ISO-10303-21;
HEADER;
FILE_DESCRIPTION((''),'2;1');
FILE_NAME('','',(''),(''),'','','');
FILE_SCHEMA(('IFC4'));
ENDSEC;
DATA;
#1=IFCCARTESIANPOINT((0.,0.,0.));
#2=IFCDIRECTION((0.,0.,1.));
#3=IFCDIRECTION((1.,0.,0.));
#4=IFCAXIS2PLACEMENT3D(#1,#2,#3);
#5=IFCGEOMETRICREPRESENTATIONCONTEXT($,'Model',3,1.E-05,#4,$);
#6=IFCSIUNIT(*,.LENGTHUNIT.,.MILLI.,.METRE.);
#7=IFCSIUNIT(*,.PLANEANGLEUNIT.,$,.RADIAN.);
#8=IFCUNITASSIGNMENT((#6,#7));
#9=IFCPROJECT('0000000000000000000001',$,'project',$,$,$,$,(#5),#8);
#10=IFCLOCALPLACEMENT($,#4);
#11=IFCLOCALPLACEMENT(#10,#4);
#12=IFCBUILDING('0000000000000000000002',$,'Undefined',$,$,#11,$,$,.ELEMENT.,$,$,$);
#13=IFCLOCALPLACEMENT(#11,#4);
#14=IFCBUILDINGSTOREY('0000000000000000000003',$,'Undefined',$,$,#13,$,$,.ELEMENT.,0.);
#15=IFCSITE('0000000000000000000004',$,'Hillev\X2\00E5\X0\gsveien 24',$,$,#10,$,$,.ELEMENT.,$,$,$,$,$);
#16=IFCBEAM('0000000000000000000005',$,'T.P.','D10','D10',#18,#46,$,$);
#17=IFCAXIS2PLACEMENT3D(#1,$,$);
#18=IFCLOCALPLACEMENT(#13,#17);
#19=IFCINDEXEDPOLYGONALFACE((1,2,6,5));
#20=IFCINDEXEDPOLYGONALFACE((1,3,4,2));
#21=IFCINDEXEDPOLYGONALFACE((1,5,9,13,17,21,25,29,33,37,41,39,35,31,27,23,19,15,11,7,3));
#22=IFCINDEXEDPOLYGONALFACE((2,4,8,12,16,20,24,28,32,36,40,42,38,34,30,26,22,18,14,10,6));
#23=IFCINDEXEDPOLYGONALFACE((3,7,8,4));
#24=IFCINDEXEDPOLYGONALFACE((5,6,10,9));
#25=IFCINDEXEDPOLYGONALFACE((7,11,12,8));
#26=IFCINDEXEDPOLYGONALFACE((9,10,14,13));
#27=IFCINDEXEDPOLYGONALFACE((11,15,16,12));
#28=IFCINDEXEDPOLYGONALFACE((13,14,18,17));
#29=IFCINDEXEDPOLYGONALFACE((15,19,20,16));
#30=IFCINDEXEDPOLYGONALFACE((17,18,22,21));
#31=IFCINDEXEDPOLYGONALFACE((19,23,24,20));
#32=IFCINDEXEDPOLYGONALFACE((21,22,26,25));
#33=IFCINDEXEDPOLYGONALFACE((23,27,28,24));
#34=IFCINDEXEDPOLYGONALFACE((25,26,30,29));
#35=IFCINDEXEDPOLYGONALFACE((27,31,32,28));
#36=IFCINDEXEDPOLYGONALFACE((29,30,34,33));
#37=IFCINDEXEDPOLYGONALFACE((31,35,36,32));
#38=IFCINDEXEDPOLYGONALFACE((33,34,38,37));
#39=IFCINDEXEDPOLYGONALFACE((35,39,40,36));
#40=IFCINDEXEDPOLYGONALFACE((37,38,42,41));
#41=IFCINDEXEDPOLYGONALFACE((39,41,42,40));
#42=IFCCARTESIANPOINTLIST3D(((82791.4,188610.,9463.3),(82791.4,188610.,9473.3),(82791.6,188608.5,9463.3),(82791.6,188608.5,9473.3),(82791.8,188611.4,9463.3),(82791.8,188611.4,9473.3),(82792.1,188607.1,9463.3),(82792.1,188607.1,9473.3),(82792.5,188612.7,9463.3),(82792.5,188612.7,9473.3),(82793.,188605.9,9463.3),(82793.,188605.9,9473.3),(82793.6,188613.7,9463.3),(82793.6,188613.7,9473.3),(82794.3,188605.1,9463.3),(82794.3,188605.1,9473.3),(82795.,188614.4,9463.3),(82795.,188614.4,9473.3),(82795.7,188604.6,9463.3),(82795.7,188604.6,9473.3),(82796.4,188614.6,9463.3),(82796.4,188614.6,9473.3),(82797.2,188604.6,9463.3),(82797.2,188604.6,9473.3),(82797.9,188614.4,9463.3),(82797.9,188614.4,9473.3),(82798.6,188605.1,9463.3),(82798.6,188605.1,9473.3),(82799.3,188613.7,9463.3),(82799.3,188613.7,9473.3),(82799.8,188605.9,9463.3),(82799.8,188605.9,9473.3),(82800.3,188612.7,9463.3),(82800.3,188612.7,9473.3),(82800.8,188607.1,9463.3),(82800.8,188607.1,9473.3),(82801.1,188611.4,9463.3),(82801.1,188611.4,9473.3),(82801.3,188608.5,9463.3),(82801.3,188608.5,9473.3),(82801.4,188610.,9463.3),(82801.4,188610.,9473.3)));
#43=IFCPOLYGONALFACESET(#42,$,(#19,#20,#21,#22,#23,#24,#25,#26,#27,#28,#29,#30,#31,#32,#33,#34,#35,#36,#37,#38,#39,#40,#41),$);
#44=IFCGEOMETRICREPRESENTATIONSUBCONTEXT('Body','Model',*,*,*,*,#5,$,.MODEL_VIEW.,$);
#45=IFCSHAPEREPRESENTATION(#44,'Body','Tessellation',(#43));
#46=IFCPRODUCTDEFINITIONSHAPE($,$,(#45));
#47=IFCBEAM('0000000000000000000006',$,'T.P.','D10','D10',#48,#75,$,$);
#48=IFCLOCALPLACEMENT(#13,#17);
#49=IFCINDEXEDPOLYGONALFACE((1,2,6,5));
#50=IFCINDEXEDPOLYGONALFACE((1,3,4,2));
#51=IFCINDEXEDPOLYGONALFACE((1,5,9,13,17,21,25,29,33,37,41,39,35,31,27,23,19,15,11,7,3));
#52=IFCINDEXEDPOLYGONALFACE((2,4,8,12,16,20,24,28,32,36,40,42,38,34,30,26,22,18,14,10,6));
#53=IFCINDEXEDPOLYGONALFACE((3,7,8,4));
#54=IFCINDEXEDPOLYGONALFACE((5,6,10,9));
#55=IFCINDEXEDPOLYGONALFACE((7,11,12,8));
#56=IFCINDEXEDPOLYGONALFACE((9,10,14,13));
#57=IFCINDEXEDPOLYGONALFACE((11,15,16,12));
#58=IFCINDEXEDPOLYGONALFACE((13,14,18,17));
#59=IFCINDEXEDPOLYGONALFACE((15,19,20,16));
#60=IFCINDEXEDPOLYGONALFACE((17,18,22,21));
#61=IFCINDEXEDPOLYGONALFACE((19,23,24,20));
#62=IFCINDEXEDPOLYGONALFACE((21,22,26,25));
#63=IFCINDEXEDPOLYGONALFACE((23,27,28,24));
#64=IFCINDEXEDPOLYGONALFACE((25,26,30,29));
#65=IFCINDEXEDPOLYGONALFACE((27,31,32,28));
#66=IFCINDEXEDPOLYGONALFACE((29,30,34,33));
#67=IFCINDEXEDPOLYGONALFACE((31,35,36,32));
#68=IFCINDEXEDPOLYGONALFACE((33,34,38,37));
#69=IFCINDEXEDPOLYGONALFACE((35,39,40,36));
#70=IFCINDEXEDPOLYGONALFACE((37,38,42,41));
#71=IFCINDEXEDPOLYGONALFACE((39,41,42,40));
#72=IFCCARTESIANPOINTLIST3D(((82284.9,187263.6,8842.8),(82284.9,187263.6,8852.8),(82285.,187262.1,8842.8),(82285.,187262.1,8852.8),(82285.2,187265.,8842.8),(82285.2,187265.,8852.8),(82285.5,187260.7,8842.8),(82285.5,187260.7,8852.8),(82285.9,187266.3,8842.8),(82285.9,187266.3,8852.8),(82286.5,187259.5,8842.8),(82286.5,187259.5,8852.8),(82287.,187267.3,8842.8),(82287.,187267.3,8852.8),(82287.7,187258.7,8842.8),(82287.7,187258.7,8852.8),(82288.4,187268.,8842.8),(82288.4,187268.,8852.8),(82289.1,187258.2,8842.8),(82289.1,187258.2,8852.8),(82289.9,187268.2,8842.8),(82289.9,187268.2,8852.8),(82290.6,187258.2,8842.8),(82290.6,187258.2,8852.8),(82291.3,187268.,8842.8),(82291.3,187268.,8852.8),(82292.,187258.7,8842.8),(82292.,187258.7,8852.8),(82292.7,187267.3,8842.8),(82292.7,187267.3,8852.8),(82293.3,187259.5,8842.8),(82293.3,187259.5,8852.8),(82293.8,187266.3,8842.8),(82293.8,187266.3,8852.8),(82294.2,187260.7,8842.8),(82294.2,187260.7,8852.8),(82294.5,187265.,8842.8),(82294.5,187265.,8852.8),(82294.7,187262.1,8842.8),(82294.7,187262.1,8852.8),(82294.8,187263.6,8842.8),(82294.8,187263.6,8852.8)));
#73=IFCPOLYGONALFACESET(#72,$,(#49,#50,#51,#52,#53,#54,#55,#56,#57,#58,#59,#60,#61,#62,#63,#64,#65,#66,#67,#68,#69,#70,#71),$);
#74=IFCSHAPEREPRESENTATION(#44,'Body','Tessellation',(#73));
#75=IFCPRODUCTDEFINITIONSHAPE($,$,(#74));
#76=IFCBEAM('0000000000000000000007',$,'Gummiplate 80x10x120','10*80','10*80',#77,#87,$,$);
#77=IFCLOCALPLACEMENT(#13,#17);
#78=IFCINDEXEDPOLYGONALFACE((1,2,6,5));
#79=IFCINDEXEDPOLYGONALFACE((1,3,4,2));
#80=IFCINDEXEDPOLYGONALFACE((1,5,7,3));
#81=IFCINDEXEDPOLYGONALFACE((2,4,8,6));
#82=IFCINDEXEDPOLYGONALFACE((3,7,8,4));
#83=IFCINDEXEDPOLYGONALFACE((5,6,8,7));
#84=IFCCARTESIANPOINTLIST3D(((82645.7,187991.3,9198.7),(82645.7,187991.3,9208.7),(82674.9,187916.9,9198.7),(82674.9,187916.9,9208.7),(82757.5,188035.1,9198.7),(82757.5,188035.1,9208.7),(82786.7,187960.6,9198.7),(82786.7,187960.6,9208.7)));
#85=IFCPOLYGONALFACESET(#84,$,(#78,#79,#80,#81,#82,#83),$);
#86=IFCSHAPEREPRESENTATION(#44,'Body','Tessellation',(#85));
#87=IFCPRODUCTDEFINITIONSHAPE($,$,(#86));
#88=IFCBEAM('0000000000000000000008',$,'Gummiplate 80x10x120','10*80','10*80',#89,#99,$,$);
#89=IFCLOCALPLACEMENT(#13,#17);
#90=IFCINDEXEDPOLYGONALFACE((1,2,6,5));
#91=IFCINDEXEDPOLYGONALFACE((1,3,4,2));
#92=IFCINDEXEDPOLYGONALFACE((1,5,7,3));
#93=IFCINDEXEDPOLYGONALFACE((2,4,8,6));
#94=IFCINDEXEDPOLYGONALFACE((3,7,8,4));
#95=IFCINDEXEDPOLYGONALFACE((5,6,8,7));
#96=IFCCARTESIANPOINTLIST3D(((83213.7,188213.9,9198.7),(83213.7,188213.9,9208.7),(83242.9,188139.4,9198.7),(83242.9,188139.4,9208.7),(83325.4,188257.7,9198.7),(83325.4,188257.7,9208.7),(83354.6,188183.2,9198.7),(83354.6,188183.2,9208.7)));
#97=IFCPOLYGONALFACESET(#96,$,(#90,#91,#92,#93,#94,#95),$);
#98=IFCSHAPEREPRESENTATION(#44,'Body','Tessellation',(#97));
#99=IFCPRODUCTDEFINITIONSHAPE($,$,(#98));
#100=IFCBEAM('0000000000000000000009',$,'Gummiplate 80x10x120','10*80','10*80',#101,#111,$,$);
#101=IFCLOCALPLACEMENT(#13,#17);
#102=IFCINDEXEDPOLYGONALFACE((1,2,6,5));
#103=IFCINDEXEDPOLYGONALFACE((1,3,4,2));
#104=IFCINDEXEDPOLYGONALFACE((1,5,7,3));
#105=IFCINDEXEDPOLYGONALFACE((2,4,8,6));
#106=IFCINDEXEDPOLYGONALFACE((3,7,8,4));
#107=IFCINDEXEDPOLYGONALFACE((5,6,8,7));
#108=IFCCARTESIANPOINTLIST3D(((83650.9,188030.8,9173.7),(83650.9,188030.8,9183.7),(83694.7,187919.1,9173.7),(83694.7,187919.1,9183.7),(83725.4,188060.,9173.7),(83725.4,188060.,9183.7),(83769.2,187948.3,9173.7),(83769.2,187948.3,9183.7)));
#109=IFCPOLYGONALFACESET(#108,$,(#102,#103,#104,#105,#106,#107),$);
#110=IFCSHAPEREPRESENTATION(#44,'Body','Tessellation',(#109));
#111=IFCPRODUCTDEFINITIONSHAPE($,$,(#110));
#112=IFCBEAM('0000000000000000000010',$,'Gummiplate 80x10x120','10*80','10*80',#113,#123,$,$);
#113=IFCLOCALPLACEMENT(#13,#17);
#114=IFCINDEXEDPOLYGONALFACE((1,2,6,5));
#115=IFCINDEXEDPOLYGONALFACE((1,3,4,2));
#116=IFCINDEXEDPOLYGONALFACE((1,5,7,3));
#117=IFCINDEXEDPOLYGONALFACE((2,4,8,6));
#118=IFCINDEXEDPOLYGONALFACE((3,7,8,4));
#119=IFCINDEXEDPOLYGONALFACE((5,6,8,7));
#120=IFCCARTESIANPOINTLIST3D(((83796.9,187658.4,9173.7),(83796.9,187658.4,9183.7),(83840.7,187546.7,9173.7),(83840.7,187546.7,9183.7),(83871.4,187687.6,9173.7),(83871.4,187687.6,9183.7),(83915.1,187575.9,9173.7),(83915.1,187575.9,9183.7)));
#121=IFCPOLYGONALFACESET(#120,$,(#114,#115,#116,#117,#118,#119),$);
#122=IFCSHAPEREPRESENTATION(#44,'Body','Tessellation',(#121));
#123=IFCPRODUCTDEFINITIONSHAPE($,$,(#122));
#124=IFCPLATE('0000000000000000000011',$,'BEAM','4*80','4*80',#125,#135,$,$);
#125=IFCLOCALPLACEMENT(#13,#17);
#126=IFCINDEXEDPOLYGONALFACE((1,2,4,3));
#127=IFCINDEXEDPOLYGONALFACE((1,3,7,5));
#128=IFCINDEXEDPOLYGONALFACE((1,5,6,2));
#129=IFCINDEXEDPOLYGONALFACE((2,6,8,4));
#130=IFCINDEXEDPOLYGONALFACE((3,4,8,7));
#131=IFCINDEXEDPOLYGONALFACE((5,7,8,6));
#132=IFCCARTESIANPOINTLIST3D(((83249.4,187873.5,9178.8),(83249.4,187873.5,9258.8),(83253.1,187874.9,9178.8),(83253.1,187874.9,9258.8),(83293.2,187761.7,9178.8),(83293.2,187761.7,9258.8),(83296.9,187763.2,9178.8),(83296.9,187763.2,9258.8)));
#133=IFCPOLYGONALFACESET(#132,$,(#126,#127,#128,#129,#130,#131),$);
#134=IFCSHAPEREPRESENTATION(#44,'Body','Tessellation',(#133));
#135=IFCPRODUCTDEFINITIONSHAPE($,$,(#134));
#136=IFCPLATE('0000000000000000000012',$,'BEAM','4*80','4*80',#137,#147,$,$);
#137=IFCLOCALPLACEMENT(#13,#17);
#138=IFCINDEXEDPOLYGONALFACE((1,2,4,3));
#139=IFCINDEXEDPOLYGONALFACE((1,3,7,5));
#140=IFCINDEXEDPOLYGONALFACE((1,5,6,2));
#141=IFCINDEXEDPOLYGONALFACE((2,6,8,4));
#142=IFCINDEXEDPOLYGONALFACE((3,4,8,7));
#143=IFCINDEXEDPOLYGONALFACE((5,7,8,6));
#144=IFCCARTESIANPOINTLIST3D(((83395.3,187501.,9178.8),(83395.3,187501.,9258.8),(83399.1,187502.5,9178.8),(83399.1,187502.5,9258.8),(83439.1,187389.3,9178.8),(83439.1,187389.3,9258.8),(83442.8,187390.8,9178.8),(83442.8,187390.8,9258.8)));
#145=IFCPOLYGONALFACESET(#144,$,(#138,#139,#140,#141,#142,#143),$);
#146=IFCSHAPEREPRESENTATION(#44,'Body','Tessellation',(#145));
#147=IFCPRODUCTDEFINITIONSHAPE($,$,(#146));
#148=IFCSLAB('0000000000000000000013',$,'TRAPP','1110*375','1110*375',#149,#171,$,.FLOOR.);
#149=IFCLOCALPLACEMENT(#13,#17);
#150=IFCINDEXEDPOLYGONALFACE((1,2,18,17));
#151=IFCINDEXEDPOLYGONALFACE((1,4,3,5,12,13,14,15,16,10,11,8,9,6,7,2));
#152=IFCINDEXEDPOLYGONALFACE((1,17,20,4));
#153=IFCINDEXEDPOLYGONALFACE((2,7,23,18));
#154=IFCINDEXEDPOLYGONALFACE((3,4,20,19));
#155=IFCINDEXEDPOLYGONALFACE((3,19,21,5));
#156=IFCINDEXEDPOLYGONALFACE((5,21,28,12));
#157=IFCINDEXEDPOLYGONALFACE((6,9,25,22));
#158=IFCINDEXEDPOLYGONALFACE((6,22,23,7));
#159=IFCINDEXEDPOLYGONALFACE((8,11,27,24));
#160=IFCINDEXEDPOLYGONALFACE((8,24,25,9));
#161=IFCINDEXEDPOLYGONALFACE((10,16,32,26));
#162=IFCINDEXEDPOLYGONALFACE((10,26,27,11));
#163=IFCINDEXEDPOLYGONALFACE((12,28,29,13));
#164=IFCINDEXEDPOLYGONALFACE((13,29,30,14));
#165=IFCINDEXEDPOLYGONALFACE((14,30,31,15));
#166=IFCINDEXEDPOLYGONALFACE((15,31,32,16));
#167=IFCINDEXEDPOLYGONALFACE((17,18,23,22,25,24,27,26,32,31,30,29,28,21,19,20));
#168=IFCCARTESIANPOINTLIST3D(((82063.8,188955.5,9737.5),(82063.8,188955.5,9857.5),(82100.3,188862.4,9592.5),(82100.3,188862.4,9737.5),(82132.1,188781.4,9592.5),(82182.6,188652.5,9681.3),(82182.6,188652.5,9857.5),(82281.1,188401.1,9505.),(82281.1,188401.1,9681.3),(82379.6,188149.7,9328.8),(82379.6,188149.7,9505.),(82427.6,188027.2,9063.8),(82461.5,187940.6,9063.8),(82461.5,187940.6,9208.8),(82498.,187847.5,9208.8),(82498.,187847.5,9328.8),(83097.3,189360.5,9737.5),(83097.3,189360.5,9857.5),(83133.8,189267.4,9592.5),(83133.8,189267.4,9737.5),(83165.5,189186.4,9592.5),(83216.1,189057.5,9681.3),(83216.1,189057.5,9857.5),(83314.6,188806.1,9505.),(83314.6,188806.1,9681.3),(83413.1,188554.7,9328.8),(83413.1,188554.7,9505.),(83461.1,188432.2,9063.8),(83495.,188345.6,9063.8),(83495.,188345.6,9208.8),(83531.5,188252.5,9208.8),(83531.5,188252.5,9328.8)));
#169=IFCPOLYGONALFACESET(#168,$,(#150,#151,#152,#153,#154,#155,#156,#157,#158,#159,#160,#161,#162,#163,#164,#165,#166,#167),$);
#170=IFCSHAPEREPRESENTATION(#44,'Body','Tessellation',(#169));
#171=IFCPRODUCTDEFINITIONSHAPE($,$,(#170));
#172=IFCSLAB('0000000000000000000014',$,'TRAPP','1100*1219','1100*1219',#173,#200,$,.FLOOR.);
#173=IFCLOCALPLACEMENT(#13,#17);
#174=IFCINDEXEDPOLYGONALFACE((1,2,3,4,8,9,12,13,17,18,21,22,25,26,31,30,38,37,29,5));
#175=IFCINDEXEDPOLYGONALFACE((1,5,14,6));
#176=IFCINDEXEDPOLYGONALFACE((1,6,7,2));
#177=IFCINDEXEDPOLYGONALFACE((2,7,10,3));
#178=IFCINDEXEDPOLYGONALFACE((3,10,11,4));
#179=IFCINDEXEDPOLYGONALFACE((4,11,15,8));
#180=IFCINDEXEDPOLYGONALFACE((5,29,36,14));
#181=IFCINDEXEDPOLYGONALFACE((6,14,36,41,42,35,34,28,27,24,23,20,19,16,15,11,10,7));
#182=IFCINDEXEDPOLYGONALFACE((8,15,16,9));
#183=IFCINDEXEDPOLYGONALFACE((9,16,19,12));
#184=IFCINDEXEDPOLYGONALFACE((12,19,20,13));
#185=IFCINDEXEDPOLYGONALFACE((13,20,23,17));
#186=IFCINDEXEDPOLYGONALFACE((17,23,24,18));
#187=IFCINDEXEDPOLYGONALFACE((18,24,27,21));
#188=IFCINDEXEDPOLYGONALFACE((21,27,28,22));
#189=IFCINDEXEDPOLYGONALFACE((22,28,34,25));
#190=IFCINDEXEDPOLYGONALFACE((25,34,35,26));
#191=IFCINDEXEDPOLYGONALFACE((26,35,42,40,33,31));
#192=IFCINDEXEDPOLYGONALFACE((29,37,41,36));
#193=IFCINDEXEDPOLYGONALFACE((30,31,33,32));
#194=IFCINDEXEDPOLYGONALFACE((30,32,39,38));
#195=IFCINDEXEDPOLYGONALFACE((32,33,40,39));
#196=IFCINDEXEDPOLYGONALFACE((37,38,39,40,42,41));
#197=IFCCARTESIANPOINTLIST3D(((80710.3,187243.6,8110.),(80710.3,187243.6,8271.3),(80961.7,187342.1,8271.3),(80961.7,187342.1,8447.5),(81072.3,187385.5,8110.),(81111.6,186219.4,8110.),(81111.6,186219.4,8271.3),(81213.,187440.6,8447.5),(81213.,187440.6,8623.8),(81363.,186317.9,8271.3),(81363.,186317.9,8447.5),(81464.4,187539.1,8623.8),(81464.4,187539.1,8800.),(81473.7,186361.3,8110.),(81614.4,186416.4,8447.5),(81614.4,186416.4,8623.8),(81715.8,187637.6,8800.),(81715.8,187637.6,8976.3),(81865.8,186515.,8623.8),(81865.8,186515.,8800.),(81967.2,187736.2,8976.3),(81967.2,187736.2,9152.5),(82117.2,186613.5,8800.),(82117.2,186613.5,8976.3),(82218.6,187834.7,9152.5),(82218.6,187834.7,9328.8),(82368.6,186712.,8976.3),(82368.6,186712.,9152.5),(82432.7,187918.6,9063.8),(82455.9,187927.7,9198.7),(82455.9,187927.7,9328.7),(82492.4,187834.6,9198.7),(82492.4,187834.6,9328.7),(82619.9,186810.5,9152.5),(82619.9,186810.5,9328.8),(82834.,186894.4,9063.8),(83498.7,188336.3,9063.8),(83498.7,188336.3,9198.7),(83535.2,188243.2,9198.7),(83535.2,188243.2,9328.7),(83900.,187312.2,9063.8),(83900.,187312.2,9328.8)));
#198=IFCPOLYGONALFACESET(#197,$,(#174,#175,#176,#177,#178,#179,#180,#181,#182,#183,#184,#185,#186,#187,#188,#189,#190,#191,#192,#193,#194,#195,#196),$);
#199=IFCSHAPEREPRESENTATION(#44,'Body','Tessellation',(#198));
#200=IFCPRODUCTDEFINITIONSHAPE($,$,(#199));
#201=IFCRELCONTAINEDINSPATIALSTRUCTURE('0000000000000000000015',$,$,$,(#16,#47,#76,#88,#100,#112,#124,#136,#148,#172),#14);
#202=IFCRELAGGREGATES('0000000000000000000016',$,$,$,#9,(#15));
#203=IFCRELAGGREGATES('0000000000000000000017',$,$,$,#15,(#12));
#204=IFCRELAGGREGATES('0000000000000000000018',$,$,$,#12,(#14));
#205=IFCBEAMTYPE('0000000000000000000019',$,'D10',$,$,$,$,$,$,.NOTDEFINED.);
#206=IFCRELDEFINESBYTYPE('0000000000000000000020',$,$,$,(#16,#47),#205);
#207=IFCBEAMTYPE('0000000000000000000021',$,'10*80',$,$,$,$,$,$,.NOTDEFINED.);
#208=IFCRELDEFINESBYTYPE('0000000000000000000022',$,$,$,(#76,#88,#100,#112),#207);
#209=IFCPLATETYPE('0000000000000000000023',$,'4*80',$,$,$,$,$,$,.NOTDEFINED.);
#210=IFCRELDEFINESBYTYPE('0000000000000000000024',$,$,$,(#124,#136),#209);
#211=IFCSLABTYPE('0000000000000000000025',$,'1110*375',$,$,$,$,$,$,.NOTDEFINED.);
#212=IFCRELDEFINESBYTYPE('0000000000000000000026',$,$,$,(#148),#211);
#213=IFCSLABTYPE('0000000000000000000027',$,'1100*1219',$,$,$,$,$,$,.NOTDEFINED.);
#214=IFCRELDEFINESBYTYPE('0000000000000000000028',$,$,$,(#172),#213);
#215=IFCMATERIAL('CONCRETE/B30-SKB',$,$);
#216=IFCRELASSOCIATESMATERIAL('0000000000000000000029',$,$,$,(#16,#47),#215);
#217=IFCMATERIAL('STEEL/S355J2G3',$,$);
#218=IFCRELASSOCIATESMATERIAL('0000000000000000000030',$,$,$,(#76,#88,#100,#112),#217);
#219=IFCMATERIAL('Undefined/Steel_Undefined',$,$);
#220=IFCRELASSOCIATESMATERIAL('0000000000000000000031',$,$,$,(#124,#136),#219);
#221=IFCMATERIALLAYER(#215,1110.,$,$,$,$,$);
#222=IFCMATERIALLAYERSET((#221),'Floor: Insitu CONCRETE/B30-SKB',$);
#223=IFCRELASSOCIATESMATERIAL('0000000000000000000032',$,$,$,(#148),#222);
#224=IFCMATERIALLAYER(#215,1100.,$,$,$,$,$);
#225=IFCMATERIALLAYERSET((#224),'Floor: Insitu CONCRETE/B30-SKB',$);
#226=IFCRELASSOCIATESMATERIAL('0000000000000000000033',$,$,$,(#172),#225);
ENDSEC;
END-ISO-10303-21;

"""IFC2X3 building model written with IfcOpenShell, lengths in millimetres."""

from ifc_helpers import new_model, si_unit, frame, frame_2d, origin_with_axes, place, context, subcontext, project, spatial, polyline, rectangle, circle, outline, extrude, boolean, material, layer, layer_set, layer_usage, type_object, element, save


model = new_model("IFC2X3")

# Units and contexts
model_context = context("Model", 3, precision=1e-05, world=origin_with_axes())
body_context = subcontext(model_context, "Body", "Model", "MODEL_VIEW")
ifc_project = project(units=[si_unit("LENGTHUNIT", "METRE", prefix="MILLI"), si_unit("PLANEANGLEUNIT", "RADIAN")], contexts=[model_context])

# Site, building, storey
site_placement = place(None, origin_with_axes())
site = spatial("IfcSite", under=ifc_project, at=site_placement, Name="Hillevågsveien 24", CompositionType="ELEMENT")
building_placement = place(site_placement, origin_with_axes())
building = spatial("IfcBuilding", under=site, at=building_placement, Name="Undefined", CompositionType="ELEMENT")
storey_placement = place(building_placement, origin_with_axes())
storey = spatial("IfcBuildingStorey", under=building, at=storey_placement, Name="Undefined", CompositionType="ELEMENT", Elevation=0.0)

# Beams
ifc_material_1 = material(Name="Undefined/Steel_Undefined")
ifc_material_2 = material(Name="CONCRETE/B30-SKB")
beam_type_1 = type_object("IfcBeamType", Name="D10", PredefinedType="NOTDEFINED")
for number, where, z_axis, x_axis, name in (
    (1, (82796.4, 188609.6, 9473.3), (-0.364877, 0.931056, 0.0), (0.0, 0.0, -1.0), "T.P."),
    (2, (82289.9, 187263.2, 8852.8), (-0.364877, 0.931056, 0.0), (0.0, 0.0, -1.0), "T.P."),
):
    element("IfcBeam", number, at=place(storey_placement, frame(where, z_axis=z_axis, x_axis=x_axis)), inside=storey, type_object=beam_type_1, material=ifc_material_2, Name=name, Description="D10", ObjectType="D10", context=body_context, shape_type="SweptSolid", body=[
        extrude(circle(Radius=5.0, at=frame_2d((0.0, 0.0), x_axis=(1.0, 0.0))), frame((10.0, 0.0, 0.0), z_axis=(-1.0, 0.0, 0.0), x_axis=(0.0, -1.0, 0.0)), (0.0, 0.0, 1.0), 10.0),
    ])
ifc_material_3 = material(Name="STEEL/S355J2G3")
beam_type_2 = type_object("IfcBeamType", Name="10*80", PredefinedType="NOTDEFINED")
for number, where, z_axis, x_axis, name in (
    (3, (82772.1, 187997.9, 9203.7), (0.0, 0.0, 1.0), (-0.931056, -0.364877, 0.0), "Gummiplate 80x10x120"),
    (4, (83340.0, 188220.5, 9203.7), (0.0, 0.0, 1.0), (-0.931056, -0.364877, 0.0), "Gummiplate 80x10x120"),
    (5, (83688.2, 188045.4, 9178.7), (0.0, 0.0, 1.0), (0.364877, -0.931056, 0.0), "Gummiplate 80x10x120"),
    (6, (83834.1, 187673.0, 9178.7), (0.0, 0.0, 1.0), (0.364877, -0.931056, 0.0), "Gummiplate 80x10x120"),
):
    element("IfcBeam", number, at=place(storey_placement, frame(where, z_axis=z_axis, x_axis=x_axis)), inside=storey, type_object=beam_type_2, material=ifc_material_3, Name=name, Description="10*80", ObjectType="10*80", context=body_context, shape_type="SweptSolid", body=[
        extrude(rectangle(XDim=80.0, YDim=10.0, at=frame_2d((0.0, 0.0), x_axis=(1.0, 0.0))), frame((120.0, 0.0, 0.0), z_axis=(-1.0, 0.0, 0.0), x_axis=(0.0, -1.0, 0.0)), (0.0, 0.0, 1.0), 120.0),
    ])

# Plates
plate_type = type_object("IfcPlateType", Name="4*80", PredefinedType="NOTDEFINED")
for number, where, z_axis, x_axis, name in (
    (7, (83295.0, 187762.5, 9258.8), (0.931056, 0.364877, 0.0), (0.0, 0.0, -1.0), "BEAM"),
    (8, (83441.0, 187390.0, 9258.8), (0.931056, 0.364877, 0.0), (0.0, 0.0, -1.0), "BEAM"),
):
    element("IfcPlate", number, at=place(storey_placement, frame(where, z_axis=z_axis, x_axis=x_axis)), inside=storey, type_object=plate_type, material=ifc_material_1, Name=name, Description="4*80", ObjectType="4*80", context=body_context, shape_type="SweptSolid", body=[
        extrude(outline(polyline([(0.0, 0.0), (80.0, 0.0), (80.0, 120.0), (0.0, 120.0), (0.0, 0.0)])), frame((0.0, 0.0, -2.0), z_axis=(0.0, 0.0, 1.0), x_axis=(1.0, 0.0, 0.0)), (0.0, 0.0, 1.0), 4.0),
    ])

# Slabs
ifc_layer_1 = layer(ifc_material_2, 1110.0)
ifc_layer_set_1 = layer_set([ifc_layer_1], Name="Floor: Insitu CONCRETE/B30-SKB")
ifc_layer_usage_1 = layer_usage(ifc_layer_set_1, "AXIS3", "POSITIVE", -555.0)
slab_type_1 = type_object("IfcSlabType", Name="1110*375", PredefinedType="NOTDEFINED")
slab_1_placement = place(storey_placement, frame((83014.8, 188050.0, 9328.8), z_axis=(-0.931056, -0.364877, 0.0), x_axis=(-0.364877, 0.931056, 0.0)))
element("IfcSlab", 9, at=slab_1_placement, inside=storey, type_object=slab_type_1, material=ifc_layer_usage_1, Name="TRAPP", Description="1110*375", ObjectType="1110*375", PredefinedType="FLOOR", context=body_context, shape_type="SweptSolid", body=[
    extrude(outline(polyline([(0.0, 0.0), (324.5, 0.0), (324.5, -176.2), (594.5, -176.2), (594.5, -352.5), (864.5, -352.5), (864.5, -528.7), (1190.0, -528.7), (1190.0, -408.7), (1090.0, -408.7), (1090.0, -263.7), (1003.0, -263.7), (193.0, 265.0), (100.0, 265.0), (100.0, 120.0), (0.0, 120.0), (0.0, 0.0)])), frame((0.0, 0.0, -555.0), z_axis=(0.0, 0.0, 1.0), x_axis=(1.0, 0.0, 0.0)), (0.0, 0.0, 1.0), 1110.0),
])
ifc_layer_2 = layer(ifc_material_2, 1100.0)
ifc_layer_set_2 = layer_set([ifc_layer_2], Name="Floor: Insitu CONCRETE/B30-SKB")
ifc_layer_usage_2 = layer_usage(ifc_layer_set_2, "AXIS3", "POSITIVE", -550.0)
slab_type_2 = type_object("IfcSlabType", Name="1100*1219", PredefinedType="NOTDEFINED")
slab_2_placement = place(storey_placement, frame((82419.3, 187322.6, 9328.8), z_axis=(-0.364877, 0.931056, 0.0), x_axis=(0.931056, 0.364877, 0.0)))
element("IfcSlab", 10, at=slab_2_placement, inside=storey, type_object=slab_type_2, material=ifc_layer_usage_2, Name="TRAPP", Description="1100*1219", ObjectType="1100*1219", PredefinedType="FLOOR", context=body_context, shape_type="CSG", body=[
    boolean("DIFFERENCE", extrude(outline(polyline([(0.0, 0.0), (1374.9, 0.0), (1374.9, 265.0), (229.9, 265.0), (-1231.1, 1218.8), (-1620.0, 1218.8), (-1620.0, 1057.5), (-1350.0, 1057.5), (-1350.0, 881.3), (-1080.0, 881.3), (-1080.0, 705.0), (-810.0, 705.0), (-810.0, 528.8), (-540.0, 528.8), (-540.0, 352.5), (-270.0, 352.5), (-270.0, 176.3), (0.0, 176.3), (0.0, 0.0)])), frame((0.0, 0.0, -550.0), z_axis=(0.0, 0.0, 1.0), x_axis=(1.0, 0.0, 0.0)), (0.0, 0.0, 1.0), 1100.0), extrude(rectangle(XDim=105.0, YDim=130.0, at=frame_2d((0.0, 0.0), x_axis=(1.0, 0.0))), frame((254.9, 65.0, 502.5), z_axis=(1.0, 0.0, -0.000001), x_axis=(0.000001, 0.0, 1.0)), (0.0, 0.0, 1.0), 1120.0)),
])

save(model, "model.ifc")
